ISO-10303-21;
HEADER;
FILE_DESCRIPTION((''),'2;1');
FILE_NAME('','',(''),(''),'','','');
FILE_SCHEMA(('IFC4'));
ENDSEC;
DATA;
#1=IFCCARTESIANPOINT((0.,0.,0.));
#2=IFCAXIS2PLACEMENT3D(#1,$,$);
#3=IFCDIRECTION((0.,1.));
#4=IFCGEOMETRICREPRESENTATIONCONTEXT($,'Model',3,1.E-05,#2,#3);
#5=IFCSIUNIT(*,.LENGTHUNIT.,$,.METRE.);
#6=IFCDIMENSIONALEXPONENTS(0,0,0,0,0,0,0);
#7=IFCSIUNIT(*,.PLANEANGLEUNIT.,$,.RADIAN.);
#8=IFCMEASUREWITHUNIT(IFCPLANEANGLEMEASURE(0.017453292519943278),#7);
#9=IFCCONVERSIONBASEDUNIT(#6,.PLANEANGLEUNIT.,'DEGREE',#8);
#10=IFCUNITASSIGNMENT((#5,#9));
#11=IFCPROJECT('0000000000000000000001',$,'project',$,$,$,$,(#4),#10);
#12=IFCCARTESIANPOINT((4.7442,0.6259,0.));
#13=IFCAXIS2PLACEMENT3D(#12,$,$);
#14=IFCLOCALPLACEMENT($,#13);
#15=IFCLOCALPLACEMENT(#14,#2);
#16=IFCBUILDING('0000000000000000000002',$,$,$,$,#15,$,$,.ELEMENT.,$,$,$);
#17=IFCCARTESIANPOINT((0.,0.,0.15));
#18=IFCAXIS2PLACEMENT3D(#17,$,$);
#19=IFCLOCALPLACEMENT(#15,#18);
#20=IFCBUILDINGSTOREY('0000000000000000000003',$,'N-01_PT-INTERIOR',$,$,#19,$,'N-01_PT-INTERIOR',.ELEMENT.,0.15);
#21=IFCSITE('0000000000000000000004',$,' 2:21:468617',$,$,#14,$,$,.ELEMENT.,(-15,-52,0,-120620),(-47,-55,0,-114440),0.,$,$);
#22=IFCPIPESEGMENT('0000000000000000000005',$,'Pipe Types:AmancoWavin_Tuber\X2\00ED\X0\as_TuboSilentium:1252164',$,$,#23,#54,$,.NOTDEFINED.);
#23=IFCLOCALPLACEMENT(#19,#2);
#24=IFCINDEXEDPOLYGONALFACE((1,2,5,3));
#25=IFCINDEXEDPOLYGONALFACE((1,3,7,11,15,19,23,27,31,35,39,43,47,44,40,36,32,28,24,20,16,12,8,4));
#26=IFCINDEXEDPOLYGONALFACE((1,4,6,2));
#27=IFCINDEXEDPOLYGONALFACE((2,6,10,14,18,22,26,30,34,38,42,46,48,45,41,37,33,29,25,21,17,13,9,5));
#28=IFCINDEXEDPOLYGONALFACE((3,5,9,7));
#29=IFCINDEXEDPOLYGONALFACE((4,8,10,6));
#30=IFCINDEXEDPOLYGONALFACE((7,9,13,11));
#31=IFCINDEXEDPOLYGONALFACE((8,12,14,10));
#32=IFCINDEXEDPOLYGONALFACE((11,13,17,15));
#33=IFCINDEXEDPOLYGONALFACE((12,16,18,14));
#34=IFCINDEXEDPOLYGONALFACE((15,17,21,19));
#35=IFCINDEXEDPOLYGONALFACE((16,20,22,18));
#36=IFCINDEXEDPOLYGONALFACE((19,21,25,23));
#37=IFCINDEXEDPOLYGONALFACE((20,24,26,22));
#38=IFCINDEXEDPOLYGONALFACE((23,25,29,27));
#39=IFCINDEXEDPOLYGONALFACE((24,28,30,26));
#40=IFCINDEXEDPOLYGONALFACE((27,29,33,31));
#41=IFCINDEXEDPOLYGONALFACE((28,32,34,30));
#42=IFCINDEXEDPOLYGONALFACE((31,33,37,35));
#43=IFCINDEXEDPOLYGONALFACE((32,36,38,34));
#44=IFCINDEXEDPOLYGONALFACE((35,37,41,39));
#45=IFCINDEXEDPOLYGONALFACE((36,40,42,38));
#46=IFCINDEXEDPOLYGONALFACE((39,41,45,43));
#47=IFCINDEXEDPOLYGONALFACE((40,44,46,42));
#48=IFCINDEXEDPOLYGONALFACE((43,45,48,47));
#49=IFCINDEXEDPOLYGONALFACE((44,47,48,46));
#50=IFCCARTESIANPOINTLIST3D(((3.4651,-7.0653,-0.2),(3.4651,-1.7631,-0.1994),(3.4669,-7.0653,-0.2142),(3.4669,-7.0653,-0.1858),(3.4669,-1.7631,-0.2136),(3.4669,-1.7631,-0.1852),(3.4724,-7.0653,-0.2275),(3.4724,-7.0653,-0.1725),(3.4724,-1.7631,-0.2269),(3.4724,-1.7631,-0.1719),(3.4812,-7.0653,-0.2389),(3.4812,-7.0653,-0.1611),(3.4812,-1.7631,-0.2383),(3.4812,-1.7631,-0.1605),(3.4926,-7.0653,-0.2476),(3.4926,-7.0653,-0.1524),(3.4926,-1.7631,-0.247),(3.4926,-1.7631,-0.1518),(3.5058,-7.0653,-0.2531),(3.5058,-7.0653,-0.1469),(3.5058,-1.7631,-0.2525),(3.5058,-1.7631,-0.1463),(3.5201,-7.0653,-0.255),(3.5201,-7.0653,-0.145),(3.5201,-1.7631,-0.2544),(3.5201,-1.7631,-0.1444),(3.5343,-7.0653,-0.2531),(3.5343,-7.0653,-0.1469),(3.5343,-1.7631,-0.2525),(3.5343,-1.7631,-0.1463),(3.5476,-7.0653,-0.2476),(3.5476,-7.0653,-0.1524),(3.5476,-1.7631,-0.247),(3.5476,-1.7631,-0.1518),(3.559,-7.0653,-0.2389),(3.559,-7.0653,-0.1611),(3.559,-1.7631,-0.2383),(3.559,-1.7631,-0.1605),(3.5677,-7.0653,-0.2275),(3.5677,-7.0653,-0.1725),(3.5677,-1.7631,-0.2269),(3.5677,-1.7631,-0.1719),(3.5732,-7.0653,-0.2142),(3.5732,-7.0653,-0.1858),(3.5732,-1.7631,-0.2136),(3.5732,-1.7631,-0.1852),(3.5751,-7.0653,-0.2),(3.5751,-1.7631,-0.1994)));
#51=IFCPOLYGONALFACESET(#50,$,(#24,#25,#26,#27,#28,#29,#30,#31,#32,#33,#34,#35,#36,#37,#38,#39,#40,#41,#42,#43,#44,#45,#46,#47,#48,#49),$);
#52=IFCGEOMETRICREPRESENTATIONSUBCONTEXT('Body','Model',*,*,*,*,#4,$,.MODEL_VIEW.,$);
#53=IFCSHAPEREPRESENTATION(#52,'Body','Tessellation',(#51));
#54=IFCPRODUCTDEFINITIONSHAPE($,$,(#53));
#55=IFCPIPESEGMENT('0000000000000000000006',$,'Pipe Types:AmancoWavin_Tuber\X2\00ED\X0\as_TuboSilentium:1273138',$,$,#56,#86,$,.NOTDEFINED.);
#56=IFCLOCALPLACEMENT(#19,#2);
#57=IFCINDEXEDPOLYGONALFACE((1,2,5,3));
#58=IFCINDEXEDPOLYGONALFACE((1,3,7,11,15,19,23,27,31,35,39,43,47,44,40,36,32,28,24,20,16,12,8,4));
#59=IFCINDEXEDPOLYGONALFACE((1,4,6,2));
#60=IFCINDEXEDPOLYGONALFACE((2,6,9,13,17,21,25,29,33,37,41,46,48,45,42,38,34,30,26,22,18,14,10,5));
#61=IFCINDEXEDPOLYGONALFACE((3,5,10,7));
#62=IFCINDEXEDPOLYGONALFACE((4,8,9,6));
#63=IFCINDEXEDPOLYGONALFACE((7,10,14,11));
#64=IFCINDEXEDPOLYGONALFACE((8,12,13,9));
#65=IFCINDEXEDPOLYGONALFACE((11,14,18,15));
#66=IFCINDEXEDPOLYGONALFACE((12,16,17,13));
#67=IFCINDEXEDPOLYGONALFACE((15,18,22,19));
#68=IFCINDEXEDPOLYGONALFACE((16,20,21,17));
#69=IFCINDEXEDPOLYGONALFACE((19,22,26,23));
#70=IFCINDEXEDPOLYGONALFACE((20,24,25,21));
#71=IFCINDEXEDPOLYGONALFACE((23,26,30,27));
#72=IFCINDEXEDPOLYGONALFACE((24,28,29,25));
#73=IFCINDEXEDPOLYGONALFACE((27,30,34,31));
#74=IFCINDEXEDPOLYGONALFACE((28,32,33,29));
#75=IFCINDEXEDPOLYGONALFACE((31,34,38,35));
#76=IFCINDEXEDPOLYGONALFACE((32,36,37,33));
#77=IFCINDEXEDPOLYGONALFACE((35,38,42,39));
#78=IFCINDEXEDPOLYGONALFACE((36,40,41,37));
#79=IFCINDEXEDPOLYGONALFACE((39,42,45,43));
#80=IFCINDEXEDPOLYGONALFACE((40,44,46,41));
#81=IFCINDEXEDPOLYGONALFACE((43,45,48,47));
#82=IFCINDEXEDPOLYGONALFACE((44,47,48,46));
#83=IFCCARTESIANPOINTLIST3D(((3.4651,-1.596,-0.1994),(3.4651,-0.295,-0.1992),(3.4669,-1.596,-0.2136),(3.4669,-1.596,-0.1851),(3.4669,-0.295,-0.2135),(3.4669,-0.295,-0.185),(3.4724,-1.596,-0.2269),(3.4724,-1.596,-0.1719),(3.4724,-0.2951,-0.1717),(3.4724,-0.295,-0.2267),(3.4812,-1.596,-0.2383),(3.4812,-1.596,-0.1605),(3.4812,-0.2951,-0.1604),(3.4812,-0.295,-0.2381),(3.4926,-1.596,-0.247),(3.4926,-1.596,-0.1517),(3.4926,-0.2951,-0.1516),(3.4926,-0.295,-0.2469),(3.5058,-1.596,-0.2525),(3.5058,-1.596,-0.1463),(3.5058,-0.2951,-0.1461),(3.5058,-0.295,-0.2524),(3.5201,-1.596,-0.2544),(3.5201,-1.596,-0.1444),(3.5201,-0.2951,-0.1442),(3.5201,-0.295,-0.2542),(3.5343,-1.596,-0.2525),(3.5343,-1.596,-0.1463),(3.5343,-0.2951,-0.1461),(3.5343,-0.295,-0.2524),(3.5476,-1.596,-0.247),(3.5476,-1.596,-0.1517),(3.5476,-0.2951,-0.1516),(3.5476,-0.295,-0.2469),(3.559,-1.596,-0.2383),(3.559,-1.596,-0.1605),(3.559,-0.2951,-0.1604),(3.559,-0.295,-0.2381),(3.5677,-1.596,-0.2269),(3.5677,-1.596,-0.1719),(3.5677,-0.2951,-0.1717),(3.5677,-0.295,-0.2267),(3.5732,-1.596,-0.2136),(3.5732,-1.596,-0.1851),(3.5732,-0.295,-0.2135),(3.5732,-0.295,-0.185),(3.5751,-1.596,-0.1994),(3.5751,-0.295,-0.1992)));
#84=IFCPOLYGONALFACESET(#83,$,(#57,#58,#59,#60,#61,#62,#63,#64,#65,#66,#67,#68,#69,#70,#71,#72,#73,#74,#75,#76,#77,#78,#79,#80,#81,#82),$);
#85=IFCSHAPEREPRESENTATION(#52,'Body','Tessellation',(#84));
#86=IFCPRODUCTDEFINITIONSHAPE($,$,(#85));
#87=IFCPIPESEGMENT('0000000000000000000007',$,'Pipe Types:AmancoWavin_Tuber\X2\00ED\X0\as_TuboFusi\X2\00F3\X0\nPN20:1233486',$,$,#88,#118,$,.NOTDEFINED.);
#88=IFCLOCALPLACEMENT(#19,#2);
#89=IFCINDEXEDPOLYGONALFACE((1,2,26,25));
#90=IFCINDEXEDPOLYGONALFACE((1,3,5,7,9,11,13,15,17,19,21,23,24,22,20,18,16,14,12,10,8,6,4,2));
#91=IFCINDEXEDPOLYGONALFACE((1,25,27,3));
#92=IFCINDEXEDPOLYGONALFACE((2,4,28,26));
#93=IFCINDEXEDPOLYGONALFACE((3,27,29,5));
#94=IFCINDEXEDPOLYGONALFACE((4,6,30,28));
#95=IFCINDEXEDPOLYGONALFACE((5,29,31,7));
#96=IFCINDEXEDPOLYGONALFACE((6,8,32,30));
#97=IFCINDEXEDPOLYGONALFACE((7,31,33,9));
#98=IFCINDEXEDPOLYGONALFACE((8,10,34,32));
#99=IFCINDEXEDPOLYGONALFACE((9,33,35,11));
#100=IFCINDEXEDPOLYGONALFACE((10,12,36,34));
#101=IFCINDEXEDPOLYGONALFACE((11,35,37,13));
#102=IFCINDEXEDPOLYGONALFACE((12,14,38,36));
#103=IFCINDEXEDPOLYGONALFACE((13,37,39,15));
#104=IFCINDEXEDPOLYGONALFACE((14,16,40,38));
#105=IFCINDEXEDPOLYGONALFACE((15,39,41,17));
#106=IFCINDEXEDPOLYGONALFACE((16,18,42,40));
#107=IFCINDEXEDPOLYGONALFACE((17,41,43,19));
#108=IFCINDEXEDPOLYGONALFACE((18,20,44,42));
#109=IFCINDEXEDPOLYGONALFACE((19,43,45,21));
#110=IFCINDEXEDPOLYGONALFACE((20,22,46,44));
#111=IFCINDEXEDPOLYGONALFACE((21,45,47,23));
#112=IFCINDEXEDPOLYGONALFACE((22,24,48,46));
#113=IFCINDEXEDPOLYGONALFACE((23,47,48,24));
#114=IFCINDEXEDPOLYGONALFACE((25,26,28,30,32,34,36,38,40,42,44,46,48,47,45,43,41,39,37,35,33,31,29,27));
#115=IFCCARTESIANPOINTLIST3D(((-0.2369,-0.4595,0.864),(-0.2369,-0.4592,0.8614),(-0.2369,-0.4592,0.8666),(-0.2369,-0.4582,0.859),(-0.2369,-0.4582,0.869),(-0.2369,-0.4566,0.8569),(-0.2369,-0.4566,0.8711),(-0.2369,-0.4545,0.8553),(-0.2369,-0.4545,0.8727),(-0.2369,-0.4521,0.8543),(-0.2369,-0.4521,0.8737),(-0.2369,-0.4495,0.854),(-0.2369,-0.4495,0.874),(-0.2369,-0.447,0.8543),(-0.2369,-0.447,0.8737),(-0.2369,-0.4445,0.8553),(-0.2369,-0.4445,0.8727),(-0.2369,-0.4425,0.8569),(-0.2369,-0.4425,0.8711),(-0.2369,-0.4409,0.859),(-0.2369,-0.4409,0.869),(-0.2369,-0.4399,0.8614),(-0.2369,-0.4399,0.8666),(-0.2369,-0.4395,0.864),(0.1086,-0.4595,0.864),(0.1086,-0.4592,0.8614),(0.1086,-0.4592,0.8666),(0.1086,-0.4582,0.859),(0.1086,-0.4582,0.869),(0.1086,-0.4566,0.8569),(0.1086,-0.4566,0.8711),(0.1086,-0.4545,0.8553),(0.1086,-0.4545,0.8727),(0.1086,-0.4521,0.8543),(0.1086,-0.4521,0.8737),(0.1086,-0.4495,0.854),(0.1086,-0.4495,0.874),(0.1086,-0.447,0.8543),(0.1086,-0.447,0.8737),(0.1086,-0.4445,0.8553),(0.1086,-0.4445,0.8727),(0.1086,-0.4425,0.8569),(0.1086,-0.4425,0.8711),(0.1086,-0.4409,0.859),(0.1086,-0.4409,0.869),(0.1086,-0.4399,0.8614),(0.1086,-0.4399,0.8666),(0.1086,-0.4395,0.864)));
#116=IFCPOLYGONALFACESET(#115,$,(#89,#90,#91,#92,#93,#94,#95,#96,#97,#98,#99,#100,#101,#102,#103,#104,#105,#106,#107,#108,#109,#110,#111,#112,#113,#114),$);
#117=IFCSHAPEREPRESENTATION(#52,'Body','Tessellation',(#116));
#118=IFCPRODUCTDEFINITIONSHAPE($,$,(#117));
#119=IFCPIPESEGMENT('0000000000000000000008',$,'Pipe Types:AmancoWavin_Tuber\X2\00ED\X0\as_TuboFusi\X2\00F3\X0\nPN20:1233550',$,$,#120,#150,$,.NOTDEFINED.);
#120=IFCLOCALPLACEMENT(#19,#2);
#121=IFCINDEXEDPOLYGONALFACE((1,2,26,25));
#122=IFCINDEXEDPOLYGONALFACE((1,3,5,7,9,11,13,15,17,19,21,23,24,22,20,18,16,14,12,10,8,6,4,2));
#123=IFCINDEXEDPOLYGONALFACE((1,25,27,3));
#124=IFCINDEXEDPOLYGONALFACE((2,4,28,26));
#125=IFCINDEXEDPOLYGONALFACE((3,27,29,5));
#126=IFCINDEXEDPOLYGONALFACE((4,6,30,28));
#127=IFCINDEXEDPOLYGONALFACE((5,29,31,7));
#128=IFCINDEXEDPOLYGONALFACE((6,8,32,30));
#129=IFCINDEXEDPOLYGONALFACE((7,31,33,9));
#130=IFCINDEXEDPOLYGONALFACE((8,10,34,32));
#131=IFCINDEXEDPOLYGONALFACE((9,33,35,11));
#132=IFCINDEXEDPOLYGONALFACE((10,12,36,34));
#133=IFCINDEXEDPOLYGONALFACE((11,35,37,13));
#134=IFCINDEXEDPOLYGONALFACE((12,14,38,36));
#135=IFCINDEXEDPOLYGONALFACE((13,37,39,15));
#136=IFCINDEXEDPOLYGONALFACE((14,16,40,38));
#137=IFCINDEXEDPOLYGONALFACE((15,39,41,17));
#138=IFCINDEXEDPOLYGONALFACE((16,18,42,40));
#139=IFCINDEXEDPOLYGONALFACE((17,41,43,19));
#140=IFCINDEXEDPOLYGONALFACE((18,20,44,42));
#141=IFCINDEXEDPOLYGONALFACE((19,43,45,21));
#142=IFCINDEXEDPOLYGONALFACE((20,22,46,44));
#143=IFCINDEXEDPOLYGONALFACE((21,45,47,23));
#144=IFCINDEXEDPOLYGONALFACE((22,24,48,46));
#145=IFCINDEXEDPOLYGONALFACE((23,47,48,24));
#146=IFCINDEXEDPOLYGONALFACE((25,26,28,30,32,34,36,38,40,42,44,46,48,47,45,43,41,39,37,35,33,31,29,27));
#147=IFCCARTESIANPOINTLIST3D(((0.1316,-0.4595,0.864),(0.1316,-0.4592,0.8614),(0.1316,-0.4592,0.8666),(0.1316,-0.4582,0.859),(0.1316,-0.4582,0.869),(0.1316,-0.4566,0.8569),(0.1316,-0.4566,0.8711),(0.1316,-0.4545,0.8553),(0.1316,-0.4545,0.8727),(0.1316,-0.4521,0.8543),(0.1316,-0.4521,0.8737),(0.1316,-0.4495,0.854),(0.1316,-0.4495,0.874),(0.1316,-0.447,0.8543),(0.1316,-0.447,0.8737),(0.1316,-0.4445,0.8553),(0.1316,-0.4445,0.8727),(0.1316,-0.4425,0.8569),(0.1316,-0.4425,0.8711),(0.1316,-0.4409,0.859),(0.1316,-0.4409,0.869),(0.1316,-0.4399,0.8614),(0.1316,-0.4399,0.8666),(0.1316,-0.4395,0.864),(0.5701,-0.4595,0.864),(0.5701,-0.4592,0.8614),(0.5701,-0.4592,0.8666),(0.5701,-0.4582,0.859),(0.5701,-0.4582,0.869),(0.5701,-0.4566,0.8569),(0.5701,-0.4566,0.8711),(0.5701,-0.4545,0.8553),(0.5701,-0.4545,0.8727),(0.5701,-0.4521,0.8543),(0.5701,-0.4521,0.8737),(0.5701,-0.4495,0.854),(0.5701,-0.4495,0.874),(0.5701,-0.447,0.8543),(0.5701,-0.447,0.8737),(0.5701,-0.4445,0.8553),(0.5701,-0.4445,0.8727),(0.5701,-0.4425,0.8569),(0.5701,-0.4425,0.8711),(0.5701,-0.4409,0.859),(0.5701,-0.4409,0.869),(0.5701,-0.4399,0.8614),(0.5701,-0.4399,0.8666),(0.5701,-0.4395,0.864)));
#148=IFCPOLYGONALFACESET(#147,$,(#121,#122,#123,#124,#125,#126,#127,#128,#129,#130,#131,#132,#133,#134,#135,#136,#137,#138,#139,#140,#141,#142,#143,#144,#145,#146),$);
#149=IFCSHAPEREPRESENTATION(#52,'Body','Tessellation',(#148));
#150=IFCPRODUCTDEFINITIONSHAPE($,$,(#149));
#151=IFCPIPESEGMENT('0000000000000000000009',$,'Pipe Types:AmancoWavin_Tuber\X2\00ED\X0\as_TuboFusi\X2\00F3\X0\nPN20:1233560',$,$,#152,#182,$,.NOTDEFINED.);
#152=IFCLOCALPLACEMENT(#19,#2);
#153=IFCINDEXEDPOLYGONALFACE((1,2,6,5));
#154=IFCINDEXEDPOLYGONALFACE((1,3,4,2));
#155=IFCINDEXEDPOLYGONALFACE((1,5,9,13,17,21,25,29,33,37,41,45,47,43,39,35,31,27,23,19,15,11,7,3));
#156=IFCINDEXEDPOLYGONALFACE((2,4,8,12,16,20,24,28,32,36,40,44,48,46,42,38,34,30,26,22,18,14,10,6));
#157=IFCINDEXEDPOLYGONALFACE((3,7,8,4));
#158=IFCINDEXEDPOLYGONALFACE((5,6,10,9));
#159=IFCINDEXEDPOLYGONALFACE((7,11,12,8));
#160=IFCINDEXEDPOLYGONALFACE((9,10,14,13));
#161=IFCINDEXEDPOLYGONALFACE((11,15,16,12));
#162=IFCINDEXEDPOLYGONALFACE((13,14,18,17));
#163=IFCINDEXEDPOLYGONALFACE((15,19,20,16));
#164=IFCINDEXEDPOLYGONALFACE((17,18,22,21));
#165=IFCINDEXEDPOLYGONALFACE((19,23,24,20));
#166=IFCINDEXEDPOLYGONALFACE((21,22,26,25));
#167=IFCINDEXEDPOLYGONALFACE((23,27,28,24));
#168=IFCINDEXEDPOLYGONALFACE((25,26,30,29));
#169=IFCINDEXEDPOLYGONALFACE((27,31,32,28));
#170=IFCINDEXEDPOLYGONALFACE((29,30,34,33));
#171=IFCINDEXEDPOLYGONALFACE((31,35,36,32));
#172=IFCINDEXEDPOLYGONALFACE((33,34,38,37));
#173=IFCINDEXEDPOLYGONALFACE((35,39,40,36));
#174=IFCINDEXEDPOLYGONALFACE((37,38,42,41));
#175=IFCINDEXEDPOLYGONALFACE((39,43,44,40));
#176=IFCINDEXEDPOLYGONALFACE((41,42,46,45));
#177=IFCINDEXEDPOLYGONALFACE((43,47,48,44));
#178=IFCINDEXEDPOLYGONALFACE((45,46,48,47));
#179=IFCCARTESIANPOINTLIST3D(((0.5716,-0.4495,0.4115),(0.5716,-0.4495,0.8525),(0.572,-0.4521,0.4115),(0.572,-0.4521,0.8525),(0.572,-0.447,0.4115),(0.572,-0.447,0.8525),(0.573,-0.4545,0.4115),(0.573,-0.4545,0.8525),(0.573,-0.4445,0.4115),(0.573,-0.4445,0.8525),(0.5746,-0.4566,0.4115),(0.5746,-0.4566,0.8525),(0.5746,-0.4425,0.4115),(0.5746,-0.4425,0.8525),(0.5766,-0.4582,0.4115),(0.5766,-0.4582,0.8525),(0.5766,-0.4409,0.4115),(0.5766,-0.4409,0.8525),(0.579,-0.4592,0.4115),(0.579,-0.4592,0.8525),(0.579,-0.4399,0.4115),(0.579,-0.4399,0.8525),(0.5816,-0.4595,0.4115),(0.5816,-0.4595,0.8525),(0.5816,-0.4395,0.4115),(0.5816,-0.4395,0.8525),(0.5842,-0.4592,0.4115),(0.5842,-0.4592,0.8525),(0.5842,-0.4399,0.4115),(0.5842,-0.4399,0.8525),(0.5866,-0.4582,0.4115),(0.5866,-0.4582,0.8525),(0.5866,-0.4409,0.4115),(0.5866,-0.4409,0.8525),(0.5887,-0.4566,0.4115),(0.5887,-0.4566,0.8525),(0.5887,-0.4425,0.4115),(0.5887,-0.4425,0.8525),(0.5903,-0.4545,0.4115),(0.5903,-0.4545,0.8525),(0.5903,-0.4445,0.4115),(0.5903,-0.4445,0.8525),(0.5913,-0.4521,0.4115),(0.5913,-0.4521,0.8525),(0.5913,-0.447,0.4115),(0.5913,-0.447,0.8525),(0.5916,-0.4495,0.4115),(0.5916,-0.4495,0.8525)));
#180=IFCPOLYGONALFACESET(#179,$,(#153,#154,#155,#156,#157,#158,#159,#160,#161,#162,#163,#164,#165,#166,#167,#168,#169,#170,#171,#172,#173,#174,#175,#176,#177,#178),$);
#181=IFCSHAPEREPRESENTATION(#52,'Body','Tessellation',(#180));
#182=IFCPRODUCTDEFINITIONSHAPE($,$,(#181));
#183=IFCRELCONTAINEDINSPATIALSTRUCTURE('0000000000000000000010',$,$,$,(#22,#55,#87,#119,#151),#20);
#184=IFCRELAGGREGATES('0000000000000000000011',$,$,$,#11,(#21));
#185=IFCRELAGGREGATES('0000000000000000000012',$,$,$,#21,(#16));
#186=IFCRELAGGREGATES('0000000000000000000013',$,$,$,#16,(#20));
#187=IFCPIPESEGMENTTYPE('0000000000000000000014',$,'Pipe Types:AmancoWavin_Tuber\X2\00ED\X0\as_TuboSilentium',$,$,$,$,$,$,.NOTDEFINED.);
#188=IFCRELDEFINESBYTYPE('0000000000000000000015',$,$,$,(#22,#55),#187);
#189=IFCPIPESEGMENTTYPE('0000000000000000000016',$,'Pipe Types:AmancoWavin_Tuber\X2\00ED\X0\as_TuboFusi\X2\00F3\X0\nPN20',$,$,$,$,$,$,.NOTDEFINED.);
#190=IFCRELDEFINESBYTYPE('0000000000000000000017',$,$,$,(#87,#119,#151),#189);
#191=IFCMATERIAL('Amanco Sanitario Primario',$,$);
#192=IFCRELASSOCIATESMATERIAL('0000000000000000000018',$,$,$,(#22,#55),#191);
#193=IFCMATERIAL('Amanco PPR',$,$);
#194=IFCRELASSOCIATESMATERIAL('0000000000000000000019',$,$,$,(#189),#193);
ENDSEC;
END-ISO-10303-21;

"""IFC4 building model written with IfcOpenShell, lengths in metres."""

from ifc_helpers import new_model, entity, si_unit, converted_unit, direction, frame, origin, place, context, subcontext, project, spatial, arc, indexed_curve, outline, extrude, material, type_object, element, save


model = new_model("IFC4")

# Units and contexts
model_context = context("Model", 3, precision=1e-05, world=origin(), true_north=direction((0.0, 1.0)))
body_context = subcontext(model_context, "Body", "Model", "MODEL_VIEW")
ifc_project = project(units=[si_unit("LENGTHUNIT", "METRE"), converted_unit("PLANEANGLEUNIT", "DEGREE", entity("IfcPlaneAngleMeasure", 0.017453292519943278), si_unit("PLANEANGLEUNIT", "RADIAN"), dimensions=[0, 0, 0, 0, 0, 0, 0])], contexts=[model_context])

# Site, building, storey
site_placement = place(None, frame((4.7442, 0.6259, 0.0)))
site = spatial("IfcSite", under=ifc_project, at=site_placement, Name=" 2:21:468617", CompositionType="ELEMENT", RefLatitude=(-15, -52, 0, -120620), RefLongitude=(-47, -55, 0, -114440), RefElevation=0.0)
building_placement = place(site_placement, origin())
building = spatial("IfcBuilding", under=site, at=building_placement, CompositionType="ELEMENT")
storey_placement = place(building_placement, frame((0.0, 0.0, 0.15)))
storey = spatial("IfcBuildingStorey", under=building, at=storey_placement, Name="N-01_PT-INTERIOR", LongName="N-01_PT-INTERIOR", CompositionType="ELEMENT", Elevation=0.15)

# Pipe segments
pipe_segment_type_1 = type_object("IfcPipeSegmentType", Name="Pipe Types:AmancoWavin_Tuberías_TuboSilentium", PredefinedType="NOTDEFINED")
ifc_material_1 = material(Name="Amanco Sanitario Primario")
pipe_segment_1_placement = place(storey_placement, origin())
element("IfcPipeSegment", 1, at=pipe_segment_1_placement, inside=storey, type_object=pipe_segment_type_1, material=ifc_material_1, Name="Pipe Types:AmancoWavin_Tuberías_TuboSilentium:1252164", PredefinedType="NOTDEFINED", context=body_context, shape_type="SweptSolid", body=[
    extrude(outline(indexed_curve([(0.055, 0.0), (0.0389, 0.0389), (0.0, 0.055), (-0.0389, 0.0389), (-0.055, 0.0), (-0.0389, -0.0389), (0.0, -0.055), (0.0389, -0.0389)], segments=[arc(1, 2, 3), arc(3, 4, 5), arc(5, 6, 7), arc(7, 8, 1)], self_intersect=False)), frame((3.5201, -7.0653, -0.2), z_axis=(0.0, 1.0, 0.000114), x_axis=(1.0, 0.0, 0.0)), (0.0, 0.0, 1.0), 5.3022),
])
pipe_segment_2_placement = place(storey_placement, origin())
element("IfcPipeSegment", 2, at=pipe_segment_2_placement, inside=storey, type_object=pipe_segment_type_1, material=ifc_material_1, Name="Pipe Types:AmancoWavin_Tuberías_TuboSilentium:1273138", PredefinedType="NOTDEFINED", context=body_context, shape_type="SweptSolid", body=[
    extrude(outline(indexed_curve([(0.055, 0.0), (0.0389, 0.0389), (0.0, 0.055), (-0.0389, 0.0389), (-0.055, 0.0), (-0.0389, -0.0389), (0.0, -0.055), (0.0389, -0.0389)], segments=[arc(1, 2, 3), arc(3, 4, 5), arc(5, 6, 7), arc(7, 8, 1)], self_intersect=False)), frame((3.5201, -1.596, -0.1994), z_axis=(0.0, 1.0, 0.000105), x_axis=(-1.0, 0.0, 0.0)), (0.0, 0.0, 1.0), 1.3009),
])
ifc_material_2 = material(Name="Amanco PPR")
pipe_segment_type_2 = type_object("IfcPipeSegmentType", Name="Pipe Types:AmancoWavin_Tuberías_TuboFusiónPN20", PredefinedType="NOTDEFINED", material=ifc_material_2)
pipe_segment_3_placement = place(storey_placement, origin())
element("IfcPipeSegment", 3, at=pipe_segment_3_placement, inside=storey, type_object=pipe_segment_type_2, Name="Pipe Types:AmancoWavin_Tuberías_TuboFusiónPN20:1233486", PredefinedType="NOTDEFINED", context=body_context, shape_type="SweptSolid", body=[
    extrude(outline(indexed_curve([(0.01, 0.0), (0.0071, 0.0071), (0.0, 0.01), (-0.0071, 0.0071), (-0.01, 0.0), (-0.0071, -0.0071), (0.0, -0.01), (0.0071, -0.0071)], segments=[arc(1, 2, 3), arc(3, 4, 5), arc(5, 6, 7), arc(7, 8, 1)], self_intersect=False)), frame((-0.2369, -0.4495, 0.864), z_axis=(1.0, 0.0, 0.0), x_axis=(0.0, 1.0, 0.0)), (0.0, 0.0, 1.0), 0.3455),
])
pipe_segment_4_placement = place(storey_placement, origin())
element("IfcPipeSegment", 4, at=pipe_segment_4_placement, inside=storey, type_object=pipe_segment_type_2, Name="Pipe Types:AmancoWavin_Tuberías_TuboFusiónPN20:1233550", PredefinedType="NOTDEFINED", context=body_context, shape_type="SweptSolid", body=[
    extrude(outline(indexed_curve([(0.01, 0.0), (0.0071, 0.0071), (0.0, 0.01), (-0.0071, 0.0071), (-0.01, 0.0), (-0.0071, -0.0071), (0.0, -0.01), (0.0071, -0.0071)], segments=[arc(1, 2, 3), arc(3, 4, 5), arc(5, 6, 7), arc(7, 8, 1)], self_intersect=False)), frame((0.1316, -0.4495, 0.864), z_axis=(1.0, 0.0, 0.0), x_axis=(0.0, -1.0, 0.0)), (0.0, 0.0, 1.0), 0.4385),
])
pipe_segment_5_placement = place(storey_placement, origin())
element("IfcPipeSegment", 5, at=pipe_segment_5_placement, inside=storey, type_object=pipe_segment_type_2, Name="Pipe Types:AmancoWavin_Tuberías_TuboFusiónPN20:1233560", PredefinedType="NOTDEFINED", context=body_context, shape_type="SweptSolid", body=[
    extrude(outline(indexed_curve([(0.01, 0.0), (0.0071, 0.0071), (0.0, 0.01), (-0.0071, 0.0071), (-0.01, 0.0), (-0.0071, -0.0071), (0.0, -0.01), (0.0071, -0.0071)], segments=[arc(1, 2, 3), arc(3, 4, 5), arc(5, 6, 7), arc(7, 8, 1)], self_intersect=False)), frame((0.5816, -0.4495, 0.4115)), (0.0, 0.0, 1.0), 0.441),
])

save(model, "model.ifc")
